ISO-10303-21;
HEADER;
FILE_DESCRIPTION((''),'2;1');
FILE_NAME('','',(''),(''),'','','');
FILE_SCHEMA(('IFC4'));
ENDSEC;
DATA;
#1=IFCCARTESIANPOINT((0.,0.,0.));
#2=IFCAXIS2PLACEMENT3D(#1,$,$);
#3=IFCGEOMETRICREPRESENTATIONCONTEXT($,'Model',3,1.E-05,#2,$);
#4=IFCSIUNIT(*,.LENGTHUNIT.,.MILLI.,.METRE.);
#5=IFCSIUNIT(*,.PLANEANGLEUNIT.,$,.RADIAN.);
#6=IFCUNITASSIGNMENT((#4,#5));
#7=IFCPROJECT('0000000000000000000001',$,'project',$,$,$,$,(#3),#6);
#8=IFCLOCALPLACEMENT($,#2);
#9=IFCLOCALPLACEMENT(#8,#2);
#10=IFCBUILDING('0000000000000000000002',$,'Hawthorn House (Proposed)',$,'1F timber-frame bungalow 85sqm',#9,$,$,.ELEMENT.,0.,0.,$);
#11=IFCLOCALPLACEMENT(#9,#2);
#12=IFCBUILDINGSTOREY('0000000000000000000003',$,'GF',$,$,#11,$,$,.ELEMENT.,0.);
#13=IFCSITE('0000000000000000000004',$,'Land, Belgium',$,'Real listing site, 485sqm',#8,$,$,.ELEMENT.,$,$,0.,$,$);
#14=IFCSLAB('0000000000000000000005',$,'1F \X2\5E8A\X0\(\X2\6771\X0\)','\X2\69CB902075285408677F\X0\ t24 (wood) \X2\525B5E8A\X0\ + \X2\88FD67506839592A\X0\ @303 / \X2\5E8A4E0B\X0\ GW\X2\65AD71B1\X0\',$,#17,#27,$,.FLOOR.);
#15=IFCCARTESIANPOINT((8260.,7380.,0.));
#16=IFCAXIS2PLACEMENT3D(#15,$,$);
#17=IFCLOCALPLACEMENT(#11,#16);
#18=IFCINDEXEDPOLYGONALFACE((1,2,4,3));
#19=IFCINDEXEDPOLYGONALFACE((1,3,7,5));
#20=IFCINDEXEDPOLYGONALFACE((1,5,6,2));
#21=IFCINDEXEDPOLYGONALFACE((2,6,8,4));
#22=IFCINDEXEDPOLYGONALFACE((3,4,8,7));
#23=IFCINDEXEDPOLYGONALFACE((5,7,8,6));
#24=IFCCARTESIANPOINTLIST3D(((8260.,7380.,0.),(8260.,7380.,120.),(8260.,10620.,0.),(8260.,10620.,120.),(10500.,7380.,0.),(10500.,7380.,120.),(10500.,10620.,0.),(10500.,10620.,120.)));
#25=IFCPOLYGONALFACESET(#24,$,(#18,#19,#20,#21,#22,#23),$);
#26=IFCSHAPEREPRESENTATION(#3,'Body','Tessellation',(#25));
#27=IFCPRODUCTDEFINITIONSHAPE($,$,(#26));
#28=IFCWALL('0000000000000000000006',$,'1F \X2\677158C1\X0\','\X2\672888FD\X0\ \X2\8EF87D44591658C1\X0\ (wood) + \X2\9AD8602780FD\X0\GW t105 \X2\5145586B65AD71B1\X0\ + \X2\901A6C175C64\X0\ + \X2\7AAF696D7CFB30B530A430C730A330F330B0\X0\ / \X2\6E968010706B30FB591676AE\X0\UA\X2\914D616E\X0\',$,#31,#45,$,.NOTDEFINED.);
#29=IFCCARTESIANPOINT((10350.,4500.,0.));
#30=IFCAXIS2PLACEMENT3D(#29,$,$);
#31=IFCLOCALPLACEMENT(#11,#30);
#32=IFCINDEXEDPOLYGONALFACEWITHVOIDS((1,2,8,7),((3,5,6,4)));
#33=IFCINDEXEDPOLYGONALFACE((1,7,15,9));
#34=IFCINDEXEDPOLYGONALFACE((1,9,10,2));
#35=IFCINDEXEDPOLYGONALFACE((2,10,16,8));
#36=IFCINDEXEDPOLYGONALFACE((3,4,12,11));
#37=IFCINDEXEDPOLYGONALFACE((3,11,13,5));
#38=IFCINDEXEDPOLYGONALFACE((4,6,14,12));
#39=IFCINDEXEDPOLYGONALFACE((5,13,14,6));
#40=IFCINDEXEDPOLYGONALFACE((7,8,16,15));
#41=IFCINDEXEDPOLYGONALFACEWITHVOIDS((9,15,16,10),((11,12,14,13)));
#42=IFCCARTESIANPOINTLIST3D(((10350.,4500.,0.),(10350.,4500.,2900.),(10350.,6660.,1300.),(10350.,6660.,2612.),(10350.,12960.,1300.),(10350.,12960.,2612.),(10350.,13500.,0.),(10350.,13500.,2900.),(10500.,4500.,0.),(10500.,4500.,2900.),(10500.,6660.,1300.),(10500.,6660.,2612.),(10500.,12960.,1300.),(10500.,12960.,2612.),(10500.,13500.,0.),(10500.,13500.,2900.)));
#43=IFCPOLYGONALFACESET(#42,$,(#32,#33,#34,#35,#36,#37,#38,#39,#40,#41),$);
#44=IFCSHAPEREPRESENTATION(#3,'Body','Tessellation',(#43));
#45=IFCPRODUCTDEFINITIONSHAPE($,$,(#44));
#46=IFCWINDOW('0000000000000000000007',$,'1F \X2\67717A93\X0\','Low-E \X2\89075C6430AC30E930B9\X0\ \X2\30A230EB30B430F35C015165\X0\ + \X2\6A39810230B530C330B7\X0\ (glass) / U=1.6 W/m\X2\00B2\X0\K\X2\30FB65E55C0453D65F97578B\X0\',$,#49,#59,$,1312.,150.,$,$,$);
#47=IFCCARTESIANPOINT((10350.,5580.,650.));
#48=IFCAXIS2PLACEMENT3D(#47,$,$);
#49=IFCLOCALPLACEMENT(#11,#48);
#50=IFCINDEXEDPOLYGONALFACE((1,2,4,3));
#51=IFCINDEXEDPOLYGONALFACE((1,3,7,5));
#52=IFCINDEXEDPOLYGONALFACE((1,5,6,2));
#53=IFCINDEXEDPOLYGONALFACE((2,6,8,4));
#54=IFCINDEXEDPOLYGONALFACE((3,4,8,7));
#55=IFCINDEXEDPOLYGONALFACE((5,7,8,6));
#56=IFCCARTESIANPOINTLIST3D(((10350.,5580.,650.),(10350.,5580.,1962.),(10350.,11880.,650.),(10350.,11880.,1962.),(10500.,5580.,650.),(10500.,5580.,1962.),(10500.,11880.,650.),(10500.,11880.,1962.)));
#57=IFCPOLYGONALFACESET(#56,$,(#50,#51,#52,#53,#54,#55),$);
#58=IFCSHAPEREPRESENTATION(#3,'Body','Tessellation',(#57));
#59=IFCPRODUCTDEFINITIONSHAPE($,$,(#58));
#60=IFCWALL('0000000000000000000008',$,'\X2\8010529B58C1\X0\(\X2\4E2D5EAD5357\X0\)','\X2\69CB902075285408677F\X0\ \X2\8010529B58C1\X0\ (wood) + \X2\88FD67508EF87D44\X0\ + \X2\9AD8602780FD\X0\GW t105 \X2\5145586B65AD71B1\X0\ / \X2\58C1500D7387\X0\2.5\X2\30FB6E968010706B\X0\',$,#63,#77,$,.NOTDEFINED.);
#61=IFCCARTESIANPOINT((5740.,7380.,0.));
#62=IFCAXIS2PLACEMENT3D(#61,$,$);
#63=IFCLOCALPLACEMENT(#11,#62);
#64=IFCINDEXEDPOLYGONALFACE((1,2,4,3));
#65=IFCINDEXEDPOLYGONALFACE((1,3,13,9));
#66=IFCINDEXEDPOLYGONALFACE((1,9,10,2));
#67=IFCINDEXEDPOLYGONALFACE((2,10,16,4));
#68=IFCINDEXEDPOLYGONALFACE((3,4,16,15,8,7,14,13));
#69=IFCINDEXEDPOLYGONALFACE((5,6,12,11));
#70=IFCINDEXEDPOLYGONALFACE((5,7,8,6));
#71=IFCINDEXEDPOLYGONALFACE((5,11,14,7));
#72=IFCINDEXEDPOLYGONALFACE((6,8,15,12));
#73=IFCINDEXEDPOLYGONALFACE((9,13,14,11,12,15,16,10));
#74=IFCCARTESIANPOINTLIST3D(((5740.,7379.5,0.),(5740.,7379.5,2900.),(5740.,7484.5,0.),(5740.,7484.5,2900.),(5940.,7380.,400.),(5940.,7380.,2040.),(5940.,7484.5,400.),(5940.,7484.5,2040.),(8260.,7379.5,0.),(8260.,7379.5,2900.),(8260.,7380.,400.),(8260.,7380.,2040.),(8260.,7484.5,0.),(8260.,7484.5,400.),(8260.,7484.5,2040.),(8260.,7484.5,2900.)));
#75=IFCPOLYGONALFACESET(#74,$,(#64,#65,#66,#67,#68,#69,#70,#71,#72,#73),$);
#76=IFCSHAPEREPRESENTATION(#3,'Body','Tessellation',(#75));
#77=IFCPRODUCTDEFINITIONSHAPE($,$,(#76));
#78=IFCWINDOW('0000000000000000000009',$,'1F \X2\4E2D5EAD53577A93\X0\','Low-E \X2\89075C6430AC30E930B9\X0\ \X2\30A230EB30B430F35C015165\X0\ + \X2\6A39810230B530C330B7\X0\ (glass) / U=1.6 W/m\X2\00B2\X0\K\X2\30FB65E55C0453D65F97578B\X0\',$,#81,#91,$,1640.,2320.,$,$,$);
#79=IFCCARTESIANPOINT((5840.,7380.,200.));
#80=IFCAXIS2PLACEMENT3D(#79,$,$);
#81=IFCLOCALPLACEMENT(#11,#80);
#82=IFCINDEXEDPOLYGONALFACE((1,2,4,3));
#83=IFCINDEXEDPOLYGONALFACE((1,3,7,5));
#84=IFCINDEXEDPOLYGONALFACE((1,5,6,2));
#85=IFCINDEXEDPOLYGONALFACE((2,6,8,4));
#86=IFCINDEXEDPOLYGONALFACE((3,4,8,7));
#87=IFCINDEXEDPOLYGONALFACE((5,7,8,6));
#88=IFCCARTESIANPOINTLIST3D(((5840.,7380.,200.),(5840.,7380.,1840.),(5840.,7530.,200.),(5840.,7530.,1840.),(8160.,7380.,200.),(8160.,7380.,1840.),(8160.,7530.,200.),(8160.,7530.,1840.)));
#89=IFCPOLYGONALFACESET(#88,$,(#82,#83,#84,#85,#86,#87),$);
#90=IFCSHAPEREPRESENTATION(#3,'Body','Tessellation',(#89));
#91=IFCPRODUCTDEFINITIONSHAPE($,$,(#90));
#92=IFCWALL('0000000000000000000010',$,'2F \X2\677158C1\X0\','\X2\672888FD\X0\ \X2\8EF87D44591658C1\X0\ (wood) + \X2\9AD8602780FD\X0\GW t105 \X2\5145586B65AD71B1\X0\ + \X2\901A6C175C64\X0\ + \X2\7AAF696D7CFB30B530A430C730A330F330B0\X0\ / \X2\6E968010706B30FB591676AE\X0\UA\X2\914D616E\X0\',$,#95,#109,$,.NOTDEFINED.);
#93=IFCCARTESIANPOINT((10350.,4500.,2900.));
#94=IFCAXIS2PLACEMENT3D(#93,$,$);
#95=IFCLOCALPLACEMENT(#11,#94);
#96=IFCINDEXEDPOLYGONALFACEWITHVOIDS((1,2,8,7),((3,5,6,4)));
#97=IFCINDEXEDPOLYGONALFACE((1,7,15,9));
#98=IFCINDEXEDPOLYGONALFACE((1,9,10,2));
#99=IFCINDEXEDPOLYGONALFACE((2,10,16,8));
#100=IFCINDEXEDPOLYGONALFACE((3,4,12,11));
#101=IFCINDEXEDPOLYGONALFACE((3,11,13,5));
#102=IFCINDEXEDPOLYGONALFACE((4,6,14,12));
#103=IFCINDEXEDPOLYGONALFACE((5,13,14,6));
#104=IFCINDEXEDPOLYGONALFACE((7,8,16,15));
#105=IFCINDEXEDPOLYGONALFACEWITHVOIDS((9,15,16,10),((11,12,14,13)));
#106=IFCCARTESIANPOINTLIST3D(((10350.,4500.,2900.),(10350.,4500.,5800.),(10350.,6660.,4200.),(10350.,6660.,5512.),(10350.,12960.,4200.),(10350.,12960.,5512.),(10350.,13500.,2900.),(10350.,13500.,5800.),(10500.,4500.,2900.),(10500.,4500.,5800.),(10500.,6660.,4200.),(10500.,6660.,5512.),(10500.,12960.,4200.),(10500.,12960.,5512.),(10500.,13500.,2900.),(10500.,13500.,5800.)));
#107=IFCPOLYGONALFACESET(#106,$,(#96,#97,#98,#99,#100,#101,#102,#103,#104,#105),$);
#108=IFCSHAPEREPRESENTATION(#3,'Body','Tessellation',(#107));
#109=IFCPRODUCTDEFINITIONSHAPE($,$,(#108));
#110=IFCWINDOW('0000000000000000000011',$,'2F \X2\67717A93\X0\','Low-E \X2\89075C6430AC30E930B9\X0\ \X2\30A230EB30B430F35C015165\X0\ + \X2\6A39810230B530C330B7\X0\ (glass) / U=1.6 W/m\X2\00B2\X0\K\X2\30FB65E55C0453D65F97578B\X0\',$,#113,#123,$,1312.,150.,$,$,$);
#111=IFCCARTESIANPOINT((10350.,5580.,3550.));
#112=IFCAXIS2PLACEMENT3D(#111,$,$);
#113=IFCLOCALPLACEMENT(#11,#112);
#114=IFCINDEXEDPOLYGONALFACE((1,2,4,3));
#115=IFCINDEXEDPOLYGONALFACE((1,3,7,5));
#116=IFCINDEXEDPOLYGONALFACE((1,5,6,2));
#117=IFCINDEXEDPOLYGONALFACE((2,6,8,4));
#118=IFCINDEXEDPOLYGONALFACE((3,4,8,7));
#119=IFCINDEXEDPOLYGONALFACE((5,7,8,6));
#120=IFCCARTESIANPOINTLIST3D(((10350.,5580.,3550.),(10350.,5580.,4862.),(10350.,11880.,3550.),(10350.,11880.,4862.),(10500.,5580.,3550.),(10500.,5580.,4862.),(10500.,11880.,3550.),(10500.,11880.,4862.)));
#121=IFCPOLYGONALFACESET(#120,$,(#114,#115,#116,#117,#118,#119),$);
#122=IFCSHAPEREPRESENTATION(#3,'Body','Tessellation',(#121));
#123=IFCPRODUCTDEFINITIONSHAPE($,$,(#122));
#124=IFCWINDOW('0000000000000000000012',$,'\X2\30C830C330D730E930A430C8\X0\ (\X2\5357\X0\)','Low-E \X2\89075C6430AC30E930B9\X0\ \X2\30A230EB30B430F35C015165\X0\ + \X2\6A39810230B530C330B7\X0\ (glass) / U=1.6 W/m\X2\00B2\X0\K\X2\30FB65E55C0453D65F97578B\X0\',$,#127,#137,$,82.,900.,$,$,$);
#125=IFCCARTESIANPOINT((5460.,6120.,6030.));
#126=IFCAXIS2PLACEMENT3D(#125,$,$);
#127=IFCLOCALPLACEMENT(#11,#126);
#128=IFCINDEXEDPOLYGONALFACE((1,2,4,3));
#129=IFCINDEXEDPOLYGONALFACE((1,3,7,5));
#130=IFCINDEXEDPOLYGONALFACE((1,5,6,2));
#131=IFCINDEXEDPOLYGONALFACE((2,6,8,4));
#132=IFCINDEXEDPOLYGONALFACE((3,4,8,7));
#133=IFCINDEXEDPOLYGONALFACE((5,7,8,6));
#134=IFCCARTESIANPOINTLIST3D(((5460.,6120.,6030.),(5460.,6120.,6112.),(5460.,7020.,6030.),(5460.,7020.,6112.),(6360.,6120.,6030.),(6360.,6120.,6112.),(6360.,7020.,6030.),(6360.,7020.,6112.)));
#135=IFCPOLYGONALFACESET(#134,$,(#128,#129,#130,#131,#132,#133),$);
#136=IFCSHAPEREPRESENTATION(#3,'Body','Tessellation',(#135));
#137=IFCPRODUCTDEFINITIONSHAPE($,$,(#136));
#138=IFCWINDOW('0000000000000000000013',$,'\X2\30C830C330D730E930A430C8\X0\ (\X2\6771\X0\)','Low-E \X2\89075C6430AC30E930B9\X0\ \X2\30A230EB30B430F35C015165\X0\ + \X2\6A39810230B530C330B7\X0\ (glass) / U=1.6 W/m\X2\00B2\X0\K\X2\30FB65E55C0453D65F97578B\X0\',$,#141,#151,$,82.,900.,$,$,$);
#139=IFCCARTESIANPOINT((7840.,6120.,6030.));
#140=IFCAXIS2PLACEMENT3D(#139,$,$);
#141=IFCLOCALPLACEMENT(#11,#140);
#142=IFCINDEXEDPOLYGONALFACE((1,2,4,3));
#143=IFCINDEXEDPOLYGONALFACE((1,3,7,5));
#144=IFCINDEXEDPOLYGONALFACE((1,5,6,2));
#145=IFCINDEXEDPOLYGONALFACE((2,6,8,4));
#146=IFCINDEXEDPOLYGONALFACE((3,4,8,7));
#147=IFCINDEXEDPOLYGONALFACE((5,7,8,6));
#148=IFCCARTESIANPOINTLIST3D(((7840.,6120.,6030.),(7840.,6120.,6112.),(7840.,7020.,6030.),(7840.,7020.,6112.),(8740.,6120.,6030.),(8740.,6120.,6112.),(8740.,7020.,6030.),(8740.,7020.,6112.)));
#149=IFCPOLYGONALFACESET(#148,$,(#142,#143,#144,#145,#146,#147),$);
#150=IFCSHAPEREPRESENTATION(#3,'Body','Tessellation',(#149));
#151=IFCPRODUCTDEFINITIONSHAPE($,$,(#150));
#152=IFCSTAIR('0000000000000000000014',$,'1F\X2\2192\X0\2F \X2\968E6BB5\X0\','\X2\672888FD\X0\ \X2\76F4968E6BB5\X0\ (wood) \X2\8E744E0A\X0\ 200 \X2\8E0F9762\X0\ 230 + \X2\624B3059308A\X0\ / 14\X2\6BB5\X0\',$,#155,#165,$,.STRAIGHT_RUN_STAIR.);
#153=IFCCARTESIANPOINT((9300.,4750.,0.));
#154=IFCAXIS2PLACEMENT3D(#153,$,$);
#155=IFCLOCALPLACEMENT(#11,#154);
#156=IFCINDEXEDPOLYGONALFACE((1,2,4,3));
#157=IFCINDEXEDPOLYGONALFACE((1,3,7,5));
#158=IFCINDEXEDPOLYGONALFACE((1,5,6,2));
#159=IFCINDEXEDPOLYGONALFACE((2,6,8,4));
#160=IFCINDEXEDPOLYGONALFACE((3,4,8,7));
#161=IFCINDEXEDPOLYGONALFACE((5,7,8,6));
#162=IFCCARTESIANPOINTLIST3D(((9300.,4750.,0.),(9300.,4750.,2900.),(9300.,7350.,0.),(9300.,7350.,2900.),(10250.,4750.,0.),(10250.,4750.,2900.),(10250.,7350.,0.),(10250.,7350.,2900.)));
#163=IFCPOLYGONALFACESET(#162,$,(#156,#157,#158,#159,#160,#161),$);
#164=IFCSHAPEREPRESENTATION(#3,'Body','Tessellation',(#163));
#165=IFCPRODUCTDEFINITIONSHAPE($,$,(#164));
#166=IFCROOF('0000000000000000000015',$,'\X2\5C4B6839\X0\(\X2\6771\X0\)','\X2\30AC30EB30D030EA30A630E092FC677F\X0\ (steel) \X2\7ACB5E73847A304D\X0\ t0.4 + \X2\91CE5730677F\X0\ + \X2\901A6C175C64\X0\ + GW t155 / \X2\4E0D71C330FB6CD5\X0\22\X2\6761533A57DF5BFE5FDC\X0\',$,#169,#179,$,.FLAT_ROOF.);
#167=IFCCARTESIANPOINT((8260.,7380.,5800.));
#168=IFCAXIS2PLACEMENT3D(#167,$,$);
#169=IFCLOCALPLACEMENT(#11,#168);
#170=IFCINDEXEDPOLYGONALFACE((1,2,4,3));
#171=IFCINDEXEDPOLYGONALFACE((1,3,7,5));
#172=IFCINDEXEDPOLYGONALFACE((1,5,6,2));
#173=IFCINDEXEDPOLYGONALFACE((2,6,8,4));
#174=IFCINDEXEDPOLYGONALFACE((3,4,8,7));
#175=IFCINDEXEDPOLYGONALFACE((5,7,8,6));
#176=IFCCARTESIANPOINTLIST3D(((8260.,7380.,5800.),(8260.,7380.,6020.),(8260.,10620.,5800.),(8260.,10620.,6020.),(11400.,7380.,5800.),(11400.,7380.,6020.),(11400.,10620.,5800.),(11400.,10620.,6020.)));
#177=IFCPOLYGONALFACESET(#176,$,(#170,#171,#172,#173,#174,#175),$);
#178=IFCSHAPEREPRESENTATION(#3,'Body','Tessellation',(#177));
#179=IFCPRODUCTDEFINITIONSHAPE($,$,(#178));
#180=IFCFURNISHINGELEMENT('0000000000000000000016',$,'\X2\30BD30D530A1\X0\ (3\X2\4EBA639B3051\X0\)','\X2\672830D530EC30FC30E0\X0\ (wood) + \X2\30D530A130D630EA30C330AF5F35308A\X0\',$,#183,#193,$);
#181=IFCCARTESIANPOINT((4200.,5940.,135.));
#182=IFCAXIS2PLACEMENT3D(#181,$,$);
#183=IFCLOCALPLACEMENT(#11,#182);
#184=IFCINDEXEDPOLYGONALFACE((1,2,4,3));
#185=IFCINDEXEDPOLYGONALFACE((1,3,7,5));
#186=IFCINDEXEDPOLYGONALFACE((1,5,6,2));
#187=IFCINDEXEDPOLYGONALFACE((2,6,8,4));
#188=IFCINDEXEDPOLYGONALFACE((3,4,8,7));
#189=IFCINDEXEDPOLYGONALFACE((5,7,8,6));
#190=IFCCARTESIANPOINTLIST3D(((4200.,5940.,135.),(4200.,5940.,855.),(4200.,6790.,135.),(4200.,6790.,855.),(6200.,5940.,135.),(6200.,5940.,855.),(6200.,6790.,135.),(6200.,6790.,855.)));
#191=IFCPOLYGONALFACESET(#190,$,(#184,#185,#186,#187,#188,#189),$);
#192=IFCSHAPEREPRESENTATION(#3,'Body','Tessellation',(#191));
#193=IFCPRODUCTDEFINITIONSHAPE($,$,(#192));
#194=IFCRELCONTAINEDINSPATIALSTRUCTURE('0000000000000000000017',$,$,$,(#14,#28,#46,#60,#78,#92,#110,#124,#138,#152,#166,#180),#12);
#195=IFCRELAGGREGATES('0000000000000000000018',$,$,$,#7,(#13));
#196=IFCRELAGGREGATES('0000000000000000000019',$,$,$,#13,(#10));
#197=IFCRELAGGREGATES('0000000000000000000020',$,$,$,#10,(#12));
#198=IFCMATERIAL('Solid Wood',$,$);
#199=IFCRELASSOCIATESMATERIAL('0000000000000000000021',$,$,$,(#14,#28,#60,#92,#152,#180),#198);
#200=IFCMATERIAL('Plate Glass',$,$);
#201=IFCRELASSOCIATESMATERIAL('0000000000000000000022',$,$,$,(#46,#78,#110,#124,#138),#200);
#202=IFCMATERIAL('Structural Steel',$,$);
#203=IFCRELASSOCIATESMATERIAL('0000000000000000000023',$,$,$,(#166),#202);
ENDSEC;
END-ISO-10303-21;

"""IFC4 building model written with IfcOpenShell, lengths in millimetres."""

from ifc_helpers import new_model, si_unit, frame, frame_2d, origin, place, context, project, spatial, rectangle, extrude, material, element, fill, save


model = new_model("IFC4")

# Units and contexts
model_context = context("Model", 3, precision=1e-05, world=origin())
ifc_project = project(units=[si_unit("LENGTHUNIT", "METRE", prefix="MILLI"), si_unit("PLANEANGLEUNIT", "RADIAN")], contexts=[model_context])

# Site, building, storey
site_placement = place(None, origin())
site = spatial("IfcSite", under=ifc_project, at=site_placement, Name="Land, Belgium", ObjectType="Real listing site, 485sqm", CompositionType="ELEMENT", RefElevation=0.0)
building_placement = place(site_placement, origin())
building = spatial("IfcBuilding", under=site, at=building_placement, Name="Hawthorn House (Proposed)", ObjectType="1F timber-frame bungalow 85sqm", CompositionType="ELEMENT", ElevationOfRefHeight=0.0, ElevationOfTerrain=0.0)
storey_placement = place(building_placement, origin())
storey = spatial("IfcBuildingStorey", under=building, at=storey_placement, Name="GF", CompositionType="ELEMENT", Elevation=0.0)

# Slab
ifc_material_1 = material(Name="Solid Wood")
slab_placement = place(storey_placement, frame((8260.0, 7380.0, 0.0)))
element("IfcSlab", 1, at=slab_placement, inside=storey, material=ifc_material_1, Name="1F 床(東)", Description="構造用合板 t24 (wood) 剛床 + 製材根太 @303 / 床下 GW断熱", PredefinedType="FLOOR", context=model_context, shape_type="SweptSolid", body=[
    extrude(rectangle(XDim=2240.0, YDim=3240.0, at=frame_2d((1120.0, 1620.0))), frame((8260.0, 7380.0, 0.0)), (0.0, 0.0, 1.0), 120.0),
])

# Walls, openings, windows
wall_1_placement = place(storey_placement, frame((10350.0, 4500.0, 0.0)))
wall_1 = element("IfcWall", 2, at=wall_1_placement, inside=storey, material=ifc_material_1, Name="1F 東壁", Description="木製 軸組外壁 (wood) + 高性能GW t105 充填断熱 + 通気層 + 窯業系サイディング / 準耐火・外皮UA配慮", PredefinedType="NOTDEFINED", context=model_context, shape_type="SweptSolid", body=[
    extrude(rectangle(XDim=150.0, YDim=9000.0, at=frame_2d((75.0, 4500.0))), frame((10350.0, 4500.0, 0.0)), (0.0, 0.0, 1.0), 2900.0),
])
opening_1_placement = place(storey_placement, frame((10350.0, 5580.0, 650.0)))
opening_1 = element("IfcOpeningElement", 3, at=opening_1_placement, cuts=wall_1, PredefinedType="NOTDEFINED", context=model_context, shape_type="SweptSolid", body=[
    extrude(rectangle(XDim=150.0, YDim=6300.0, at=frame_2d((75.0, 3150.0))), frame((10350.0, 5580.0, 650.0)), (0.0, 0.0, 1.0), 1312.0),
])
ifc_material_2 = material(Name="Plate Glass")
window_1_placement = place(storey_placement, frame((10350.0, 5580.0, 650.0)))
window_1 = element("IfcWindow", 4, at=window_1_placement, inside=storey, material=ifc_material_2, Name="1F 東窓", Description="Low-E 複層ガラス アルゴン封入 + 樹脂サッシ (glass) / U=1.6 W/m²K・日射取得型", OverallHeight=1312.0, OverallWidth=150.0, context=model_context, shape_type="SweptSolid", body=[
    extrude(rectangle(XDim=150.0, YDim=6300.0, at=frame_2d((75.0, 3150.0))), frame((10350.0, 5580.0, 650.0)), (0.0, 0.0, 1.0), 1312.0),
])
fill(opening_1, window_1)
wall_2_placement = place(storey_placement, frame((5740.0, 7380.0, 0.0)))
wall_2 = element("IfcWall", 5, at=wall_2_placement, inside=storey, material=ifc_material_1, Name="耐力壁(中庭南)", Description="構造用合板 耐力壁 (wood) + 製材軸組 + 高性能GW t105 充填断熱 / 壁倍率2.5・準耐火", PredefinedType="NOTDEFINED", context=model_context, shape_type="SweptSolid", body=[
    extrude(rectangle(XDim=2520.0, YDim=105.0, at=frame_2d((1260.0, 52.0))), frame((5740.0, 7380.0, 0.0)), (0.0, 0.0, 1.0), 2900.0),
])
opening_2_placement = place(storey_placement, frame((5840.0, 7380.0, 200.0)))
opening_2 = element("IfcOpeningElement", 6, at=opening_2_placement, cuts=wall_2, PredefinedType="NOTDEFINED", context=model_context, shape_type="SweptSolid", body=[
    extrude(rectangle(XDim=2320.0, YDim=150.0, at=frame_2d((1160.0, 75.0))), frame((5840.0, 7380.0, 200.0)), (0.0, 0.0, 1.0), 1640.0),
])
window_2_placement = place(storey_placement, frame((5840.0, 7380.0, 200.0)))
window_2 = element("IfcWindow", 7, at=window_2_placement, inside=storey, material=ifc_material_2, Name="1F 中庭南窓", Description="Low-E 複層ガラス アルゴン封入 + 樹脂サッシ (glass) / U=1.6 W/m²K・日射取得型", OverallHeight=1640.0, OverallWidth=2320.0, context=model_context, shape_type="SweptSolid", body=[
    extrude(rectangle(XDim=2320.0, YDim=150.0, at=frame_2d((1160.0, 75.0))), frame((5840.0, 7380.0, 200.0)), (0.0, 0.0, 1.0), 1640.0),
])
fill(opening_2, window_2)

# Wall, opening, window
wall_3_placement = place(storey_placement, frame((10350.0, 4500.0, 2900.0)))
wall_3 = element("IfcWall", 8, at=wall_3_placement, inside=storey, material=ifc_material_1, Name="2F 東壁", Description="木製 軸組外壁 (wood) + 高性能GW t105 充填断熱 + 通気層 + 窯業系サイディング / 準耐火・外皮UA配慮", PredefinedType="NOTDEFINED", context=model_context, shape_type="SweptSolid", body=[
    extrude(rectangle(XDim=150.0, YDim=9000.0, at=frame_2d((75.0, 4500.0))), frame((10350.0, 4500.0, 2900.0)), (0.0, 0.0, 1.0), 2900.0),
])
opening_3_placement = place(storey_placement, frame((10350.0, 5580.0, 3550.0)))
opening_3 = element("IfcOpeningElement", 9, at=opening_3_placement, cuts=wall_3, PredefinedType="NOTDEFINED", context=model_context, shape_type="SweptSolid", body=[
    extrude(rectangle(XDim=150.0, YDim=6300.0, at=frame_2d((75.0, 3150.0))), frame((10350.0, 5580.0, 3550.0)), (0.0, 0.0, 1.0), 1312.0),
])
window_3_placement = place(storey_placement, frame((10350.0, 5580.0, 3550.0)))
window_3 = element("IfcWindow", 10, at=window_3_placement, inside=storey, material=ifc_material_2, Name="2F 東窓", Description="Low-E 複層ガラス アルゴン封入 + 樹脂サッシ (glass) / U=1.6 W/m²K・日射取得型", OverallHeight=1312.0, OverallWidth=150.0, context=model_context, shape_type="SweptSolid", body=[
    extrude(rectangle(XDim=150.0, YDim=6300.0, at=frame_2d((75.0, 3150.0))), frame((10350.0, 5580.0, 3550.0)), (0.0, 0.0, 1.0), 1312.0),
])
fill(opening_3, window_3)

# Windows
window_4_placement = place(storey_placement, frame((5460.0, 6120.0, 6030.0)))
element("IfcWindow", 11, at=window_4_placement, inside=storey, material=ifc_material_2, Name="トップライト (南)", Description="Low-E 複層ガラス アルゴン封入 + 樹脂サッシ (glass) / U=1.6 W/m²K・日射取得型", OverallHeight=82.0, OverallWidth=900.0, context=model_context, shape_type="SweptSolid", body=[
    extrude(rectangle(XDim=900.0, YDim=900.0, at=frame_2d((450.0, 450.0))), frame((5460.0, 6120.0, 6030.0)), (0.0, 0.0, 1.0), 82.0),
])
window_5_placement = place(storey_placement, frame((7840.0, 6120.0, 6030.0)))
element("IfcWindow", 12, at=window_5_placement, inside=storey, material=ifc_material_2, Name="トップライト (東)", Description="Low-E 複層ガラス アルゴン封入 + 樹脂サッシ (glass) / U=1.6 W/m²K・日射取得型", OverallHeight=82.0, OverallWidth=900.0, context=model_context, shape_type="SweptSolid", body=[
    extrude(rectangle(XDim=900.0, YDim=900.0, at=frame_2d((450.0, 450.0))), frame((7840.0, 6120.0, 6030.0)), (0.0, 0.0, 1.0), 82.0),
])

# Stair
stair_placement = place(storey_placement, frame((9300.0, 4750.0, 0.0)))
element("IfcStair", 13, at=stair_placement, inside=storey, material=ifc_material_1, Name="1F→2F 階段", Description="木製 直階段 (wood) 蹴上 200 踏面 230 + 手すり / 14段", PredefinedType="STRAIGHT_RUN_STAIR", context=model_context, shape_type="SweptSolid", body=[
    extrude(rectangle(XDim=950.0, YDim=2600.0, at=frame_2d((475.0, 1300.0))), frame((9300.0, 4750.0, 0.0)), (0.0, 0.0, 1.0), 2900.0),
])

# Roof
ifc_material_3 = material(Name="Structural Steel")
roof_placement = place(storey_placement, frame((8260.0, 7380.0, 5800.0)))
element("IfcRoof", 14, at=roof_placement, inside=storey, material=ifc_material_3, Name="屋根(東)", Description="ガルバリウム鋼板 (steel) 立平葺き t0.4 + 野地板 + 通気層 + GW t155 / 不燃・法22条区域対応", PredefinedType="FLAT_ROOF", context=model_context, shape_type="SweptSolid", body=[
    extrude(rectangle(XDim=3140.0, YDim=3240.0, at=frame_2d((1570.0, 1620.0))), frame((8260.0, 7380.0, 5800.0)), (0.0, 0.0, 1.0), 220.0),
])

# Furnishing element
furnishing_1_placement = place(storey_placement, frame((4200.0, 5940.0, 135.0)))
element("IfcFurnishingElement", 15, at=furnishing_1_placement, inside=storey, material=ifc_material_1, Name="ソファ (3人掛け)", Description="木フレーム (wood) + ファブリック張り", context=model_context, shape_type="SweptSolid", body=[
    extrude(rectangle(XDim=2000.0, YDim=850.0, at=frame_2d((1000.0, 425.0))), frame((4200.0, 5940.0, 135.0)), (0.0, 0.0, 1.0), 720.0),
])

save(model, "model.ifc")
